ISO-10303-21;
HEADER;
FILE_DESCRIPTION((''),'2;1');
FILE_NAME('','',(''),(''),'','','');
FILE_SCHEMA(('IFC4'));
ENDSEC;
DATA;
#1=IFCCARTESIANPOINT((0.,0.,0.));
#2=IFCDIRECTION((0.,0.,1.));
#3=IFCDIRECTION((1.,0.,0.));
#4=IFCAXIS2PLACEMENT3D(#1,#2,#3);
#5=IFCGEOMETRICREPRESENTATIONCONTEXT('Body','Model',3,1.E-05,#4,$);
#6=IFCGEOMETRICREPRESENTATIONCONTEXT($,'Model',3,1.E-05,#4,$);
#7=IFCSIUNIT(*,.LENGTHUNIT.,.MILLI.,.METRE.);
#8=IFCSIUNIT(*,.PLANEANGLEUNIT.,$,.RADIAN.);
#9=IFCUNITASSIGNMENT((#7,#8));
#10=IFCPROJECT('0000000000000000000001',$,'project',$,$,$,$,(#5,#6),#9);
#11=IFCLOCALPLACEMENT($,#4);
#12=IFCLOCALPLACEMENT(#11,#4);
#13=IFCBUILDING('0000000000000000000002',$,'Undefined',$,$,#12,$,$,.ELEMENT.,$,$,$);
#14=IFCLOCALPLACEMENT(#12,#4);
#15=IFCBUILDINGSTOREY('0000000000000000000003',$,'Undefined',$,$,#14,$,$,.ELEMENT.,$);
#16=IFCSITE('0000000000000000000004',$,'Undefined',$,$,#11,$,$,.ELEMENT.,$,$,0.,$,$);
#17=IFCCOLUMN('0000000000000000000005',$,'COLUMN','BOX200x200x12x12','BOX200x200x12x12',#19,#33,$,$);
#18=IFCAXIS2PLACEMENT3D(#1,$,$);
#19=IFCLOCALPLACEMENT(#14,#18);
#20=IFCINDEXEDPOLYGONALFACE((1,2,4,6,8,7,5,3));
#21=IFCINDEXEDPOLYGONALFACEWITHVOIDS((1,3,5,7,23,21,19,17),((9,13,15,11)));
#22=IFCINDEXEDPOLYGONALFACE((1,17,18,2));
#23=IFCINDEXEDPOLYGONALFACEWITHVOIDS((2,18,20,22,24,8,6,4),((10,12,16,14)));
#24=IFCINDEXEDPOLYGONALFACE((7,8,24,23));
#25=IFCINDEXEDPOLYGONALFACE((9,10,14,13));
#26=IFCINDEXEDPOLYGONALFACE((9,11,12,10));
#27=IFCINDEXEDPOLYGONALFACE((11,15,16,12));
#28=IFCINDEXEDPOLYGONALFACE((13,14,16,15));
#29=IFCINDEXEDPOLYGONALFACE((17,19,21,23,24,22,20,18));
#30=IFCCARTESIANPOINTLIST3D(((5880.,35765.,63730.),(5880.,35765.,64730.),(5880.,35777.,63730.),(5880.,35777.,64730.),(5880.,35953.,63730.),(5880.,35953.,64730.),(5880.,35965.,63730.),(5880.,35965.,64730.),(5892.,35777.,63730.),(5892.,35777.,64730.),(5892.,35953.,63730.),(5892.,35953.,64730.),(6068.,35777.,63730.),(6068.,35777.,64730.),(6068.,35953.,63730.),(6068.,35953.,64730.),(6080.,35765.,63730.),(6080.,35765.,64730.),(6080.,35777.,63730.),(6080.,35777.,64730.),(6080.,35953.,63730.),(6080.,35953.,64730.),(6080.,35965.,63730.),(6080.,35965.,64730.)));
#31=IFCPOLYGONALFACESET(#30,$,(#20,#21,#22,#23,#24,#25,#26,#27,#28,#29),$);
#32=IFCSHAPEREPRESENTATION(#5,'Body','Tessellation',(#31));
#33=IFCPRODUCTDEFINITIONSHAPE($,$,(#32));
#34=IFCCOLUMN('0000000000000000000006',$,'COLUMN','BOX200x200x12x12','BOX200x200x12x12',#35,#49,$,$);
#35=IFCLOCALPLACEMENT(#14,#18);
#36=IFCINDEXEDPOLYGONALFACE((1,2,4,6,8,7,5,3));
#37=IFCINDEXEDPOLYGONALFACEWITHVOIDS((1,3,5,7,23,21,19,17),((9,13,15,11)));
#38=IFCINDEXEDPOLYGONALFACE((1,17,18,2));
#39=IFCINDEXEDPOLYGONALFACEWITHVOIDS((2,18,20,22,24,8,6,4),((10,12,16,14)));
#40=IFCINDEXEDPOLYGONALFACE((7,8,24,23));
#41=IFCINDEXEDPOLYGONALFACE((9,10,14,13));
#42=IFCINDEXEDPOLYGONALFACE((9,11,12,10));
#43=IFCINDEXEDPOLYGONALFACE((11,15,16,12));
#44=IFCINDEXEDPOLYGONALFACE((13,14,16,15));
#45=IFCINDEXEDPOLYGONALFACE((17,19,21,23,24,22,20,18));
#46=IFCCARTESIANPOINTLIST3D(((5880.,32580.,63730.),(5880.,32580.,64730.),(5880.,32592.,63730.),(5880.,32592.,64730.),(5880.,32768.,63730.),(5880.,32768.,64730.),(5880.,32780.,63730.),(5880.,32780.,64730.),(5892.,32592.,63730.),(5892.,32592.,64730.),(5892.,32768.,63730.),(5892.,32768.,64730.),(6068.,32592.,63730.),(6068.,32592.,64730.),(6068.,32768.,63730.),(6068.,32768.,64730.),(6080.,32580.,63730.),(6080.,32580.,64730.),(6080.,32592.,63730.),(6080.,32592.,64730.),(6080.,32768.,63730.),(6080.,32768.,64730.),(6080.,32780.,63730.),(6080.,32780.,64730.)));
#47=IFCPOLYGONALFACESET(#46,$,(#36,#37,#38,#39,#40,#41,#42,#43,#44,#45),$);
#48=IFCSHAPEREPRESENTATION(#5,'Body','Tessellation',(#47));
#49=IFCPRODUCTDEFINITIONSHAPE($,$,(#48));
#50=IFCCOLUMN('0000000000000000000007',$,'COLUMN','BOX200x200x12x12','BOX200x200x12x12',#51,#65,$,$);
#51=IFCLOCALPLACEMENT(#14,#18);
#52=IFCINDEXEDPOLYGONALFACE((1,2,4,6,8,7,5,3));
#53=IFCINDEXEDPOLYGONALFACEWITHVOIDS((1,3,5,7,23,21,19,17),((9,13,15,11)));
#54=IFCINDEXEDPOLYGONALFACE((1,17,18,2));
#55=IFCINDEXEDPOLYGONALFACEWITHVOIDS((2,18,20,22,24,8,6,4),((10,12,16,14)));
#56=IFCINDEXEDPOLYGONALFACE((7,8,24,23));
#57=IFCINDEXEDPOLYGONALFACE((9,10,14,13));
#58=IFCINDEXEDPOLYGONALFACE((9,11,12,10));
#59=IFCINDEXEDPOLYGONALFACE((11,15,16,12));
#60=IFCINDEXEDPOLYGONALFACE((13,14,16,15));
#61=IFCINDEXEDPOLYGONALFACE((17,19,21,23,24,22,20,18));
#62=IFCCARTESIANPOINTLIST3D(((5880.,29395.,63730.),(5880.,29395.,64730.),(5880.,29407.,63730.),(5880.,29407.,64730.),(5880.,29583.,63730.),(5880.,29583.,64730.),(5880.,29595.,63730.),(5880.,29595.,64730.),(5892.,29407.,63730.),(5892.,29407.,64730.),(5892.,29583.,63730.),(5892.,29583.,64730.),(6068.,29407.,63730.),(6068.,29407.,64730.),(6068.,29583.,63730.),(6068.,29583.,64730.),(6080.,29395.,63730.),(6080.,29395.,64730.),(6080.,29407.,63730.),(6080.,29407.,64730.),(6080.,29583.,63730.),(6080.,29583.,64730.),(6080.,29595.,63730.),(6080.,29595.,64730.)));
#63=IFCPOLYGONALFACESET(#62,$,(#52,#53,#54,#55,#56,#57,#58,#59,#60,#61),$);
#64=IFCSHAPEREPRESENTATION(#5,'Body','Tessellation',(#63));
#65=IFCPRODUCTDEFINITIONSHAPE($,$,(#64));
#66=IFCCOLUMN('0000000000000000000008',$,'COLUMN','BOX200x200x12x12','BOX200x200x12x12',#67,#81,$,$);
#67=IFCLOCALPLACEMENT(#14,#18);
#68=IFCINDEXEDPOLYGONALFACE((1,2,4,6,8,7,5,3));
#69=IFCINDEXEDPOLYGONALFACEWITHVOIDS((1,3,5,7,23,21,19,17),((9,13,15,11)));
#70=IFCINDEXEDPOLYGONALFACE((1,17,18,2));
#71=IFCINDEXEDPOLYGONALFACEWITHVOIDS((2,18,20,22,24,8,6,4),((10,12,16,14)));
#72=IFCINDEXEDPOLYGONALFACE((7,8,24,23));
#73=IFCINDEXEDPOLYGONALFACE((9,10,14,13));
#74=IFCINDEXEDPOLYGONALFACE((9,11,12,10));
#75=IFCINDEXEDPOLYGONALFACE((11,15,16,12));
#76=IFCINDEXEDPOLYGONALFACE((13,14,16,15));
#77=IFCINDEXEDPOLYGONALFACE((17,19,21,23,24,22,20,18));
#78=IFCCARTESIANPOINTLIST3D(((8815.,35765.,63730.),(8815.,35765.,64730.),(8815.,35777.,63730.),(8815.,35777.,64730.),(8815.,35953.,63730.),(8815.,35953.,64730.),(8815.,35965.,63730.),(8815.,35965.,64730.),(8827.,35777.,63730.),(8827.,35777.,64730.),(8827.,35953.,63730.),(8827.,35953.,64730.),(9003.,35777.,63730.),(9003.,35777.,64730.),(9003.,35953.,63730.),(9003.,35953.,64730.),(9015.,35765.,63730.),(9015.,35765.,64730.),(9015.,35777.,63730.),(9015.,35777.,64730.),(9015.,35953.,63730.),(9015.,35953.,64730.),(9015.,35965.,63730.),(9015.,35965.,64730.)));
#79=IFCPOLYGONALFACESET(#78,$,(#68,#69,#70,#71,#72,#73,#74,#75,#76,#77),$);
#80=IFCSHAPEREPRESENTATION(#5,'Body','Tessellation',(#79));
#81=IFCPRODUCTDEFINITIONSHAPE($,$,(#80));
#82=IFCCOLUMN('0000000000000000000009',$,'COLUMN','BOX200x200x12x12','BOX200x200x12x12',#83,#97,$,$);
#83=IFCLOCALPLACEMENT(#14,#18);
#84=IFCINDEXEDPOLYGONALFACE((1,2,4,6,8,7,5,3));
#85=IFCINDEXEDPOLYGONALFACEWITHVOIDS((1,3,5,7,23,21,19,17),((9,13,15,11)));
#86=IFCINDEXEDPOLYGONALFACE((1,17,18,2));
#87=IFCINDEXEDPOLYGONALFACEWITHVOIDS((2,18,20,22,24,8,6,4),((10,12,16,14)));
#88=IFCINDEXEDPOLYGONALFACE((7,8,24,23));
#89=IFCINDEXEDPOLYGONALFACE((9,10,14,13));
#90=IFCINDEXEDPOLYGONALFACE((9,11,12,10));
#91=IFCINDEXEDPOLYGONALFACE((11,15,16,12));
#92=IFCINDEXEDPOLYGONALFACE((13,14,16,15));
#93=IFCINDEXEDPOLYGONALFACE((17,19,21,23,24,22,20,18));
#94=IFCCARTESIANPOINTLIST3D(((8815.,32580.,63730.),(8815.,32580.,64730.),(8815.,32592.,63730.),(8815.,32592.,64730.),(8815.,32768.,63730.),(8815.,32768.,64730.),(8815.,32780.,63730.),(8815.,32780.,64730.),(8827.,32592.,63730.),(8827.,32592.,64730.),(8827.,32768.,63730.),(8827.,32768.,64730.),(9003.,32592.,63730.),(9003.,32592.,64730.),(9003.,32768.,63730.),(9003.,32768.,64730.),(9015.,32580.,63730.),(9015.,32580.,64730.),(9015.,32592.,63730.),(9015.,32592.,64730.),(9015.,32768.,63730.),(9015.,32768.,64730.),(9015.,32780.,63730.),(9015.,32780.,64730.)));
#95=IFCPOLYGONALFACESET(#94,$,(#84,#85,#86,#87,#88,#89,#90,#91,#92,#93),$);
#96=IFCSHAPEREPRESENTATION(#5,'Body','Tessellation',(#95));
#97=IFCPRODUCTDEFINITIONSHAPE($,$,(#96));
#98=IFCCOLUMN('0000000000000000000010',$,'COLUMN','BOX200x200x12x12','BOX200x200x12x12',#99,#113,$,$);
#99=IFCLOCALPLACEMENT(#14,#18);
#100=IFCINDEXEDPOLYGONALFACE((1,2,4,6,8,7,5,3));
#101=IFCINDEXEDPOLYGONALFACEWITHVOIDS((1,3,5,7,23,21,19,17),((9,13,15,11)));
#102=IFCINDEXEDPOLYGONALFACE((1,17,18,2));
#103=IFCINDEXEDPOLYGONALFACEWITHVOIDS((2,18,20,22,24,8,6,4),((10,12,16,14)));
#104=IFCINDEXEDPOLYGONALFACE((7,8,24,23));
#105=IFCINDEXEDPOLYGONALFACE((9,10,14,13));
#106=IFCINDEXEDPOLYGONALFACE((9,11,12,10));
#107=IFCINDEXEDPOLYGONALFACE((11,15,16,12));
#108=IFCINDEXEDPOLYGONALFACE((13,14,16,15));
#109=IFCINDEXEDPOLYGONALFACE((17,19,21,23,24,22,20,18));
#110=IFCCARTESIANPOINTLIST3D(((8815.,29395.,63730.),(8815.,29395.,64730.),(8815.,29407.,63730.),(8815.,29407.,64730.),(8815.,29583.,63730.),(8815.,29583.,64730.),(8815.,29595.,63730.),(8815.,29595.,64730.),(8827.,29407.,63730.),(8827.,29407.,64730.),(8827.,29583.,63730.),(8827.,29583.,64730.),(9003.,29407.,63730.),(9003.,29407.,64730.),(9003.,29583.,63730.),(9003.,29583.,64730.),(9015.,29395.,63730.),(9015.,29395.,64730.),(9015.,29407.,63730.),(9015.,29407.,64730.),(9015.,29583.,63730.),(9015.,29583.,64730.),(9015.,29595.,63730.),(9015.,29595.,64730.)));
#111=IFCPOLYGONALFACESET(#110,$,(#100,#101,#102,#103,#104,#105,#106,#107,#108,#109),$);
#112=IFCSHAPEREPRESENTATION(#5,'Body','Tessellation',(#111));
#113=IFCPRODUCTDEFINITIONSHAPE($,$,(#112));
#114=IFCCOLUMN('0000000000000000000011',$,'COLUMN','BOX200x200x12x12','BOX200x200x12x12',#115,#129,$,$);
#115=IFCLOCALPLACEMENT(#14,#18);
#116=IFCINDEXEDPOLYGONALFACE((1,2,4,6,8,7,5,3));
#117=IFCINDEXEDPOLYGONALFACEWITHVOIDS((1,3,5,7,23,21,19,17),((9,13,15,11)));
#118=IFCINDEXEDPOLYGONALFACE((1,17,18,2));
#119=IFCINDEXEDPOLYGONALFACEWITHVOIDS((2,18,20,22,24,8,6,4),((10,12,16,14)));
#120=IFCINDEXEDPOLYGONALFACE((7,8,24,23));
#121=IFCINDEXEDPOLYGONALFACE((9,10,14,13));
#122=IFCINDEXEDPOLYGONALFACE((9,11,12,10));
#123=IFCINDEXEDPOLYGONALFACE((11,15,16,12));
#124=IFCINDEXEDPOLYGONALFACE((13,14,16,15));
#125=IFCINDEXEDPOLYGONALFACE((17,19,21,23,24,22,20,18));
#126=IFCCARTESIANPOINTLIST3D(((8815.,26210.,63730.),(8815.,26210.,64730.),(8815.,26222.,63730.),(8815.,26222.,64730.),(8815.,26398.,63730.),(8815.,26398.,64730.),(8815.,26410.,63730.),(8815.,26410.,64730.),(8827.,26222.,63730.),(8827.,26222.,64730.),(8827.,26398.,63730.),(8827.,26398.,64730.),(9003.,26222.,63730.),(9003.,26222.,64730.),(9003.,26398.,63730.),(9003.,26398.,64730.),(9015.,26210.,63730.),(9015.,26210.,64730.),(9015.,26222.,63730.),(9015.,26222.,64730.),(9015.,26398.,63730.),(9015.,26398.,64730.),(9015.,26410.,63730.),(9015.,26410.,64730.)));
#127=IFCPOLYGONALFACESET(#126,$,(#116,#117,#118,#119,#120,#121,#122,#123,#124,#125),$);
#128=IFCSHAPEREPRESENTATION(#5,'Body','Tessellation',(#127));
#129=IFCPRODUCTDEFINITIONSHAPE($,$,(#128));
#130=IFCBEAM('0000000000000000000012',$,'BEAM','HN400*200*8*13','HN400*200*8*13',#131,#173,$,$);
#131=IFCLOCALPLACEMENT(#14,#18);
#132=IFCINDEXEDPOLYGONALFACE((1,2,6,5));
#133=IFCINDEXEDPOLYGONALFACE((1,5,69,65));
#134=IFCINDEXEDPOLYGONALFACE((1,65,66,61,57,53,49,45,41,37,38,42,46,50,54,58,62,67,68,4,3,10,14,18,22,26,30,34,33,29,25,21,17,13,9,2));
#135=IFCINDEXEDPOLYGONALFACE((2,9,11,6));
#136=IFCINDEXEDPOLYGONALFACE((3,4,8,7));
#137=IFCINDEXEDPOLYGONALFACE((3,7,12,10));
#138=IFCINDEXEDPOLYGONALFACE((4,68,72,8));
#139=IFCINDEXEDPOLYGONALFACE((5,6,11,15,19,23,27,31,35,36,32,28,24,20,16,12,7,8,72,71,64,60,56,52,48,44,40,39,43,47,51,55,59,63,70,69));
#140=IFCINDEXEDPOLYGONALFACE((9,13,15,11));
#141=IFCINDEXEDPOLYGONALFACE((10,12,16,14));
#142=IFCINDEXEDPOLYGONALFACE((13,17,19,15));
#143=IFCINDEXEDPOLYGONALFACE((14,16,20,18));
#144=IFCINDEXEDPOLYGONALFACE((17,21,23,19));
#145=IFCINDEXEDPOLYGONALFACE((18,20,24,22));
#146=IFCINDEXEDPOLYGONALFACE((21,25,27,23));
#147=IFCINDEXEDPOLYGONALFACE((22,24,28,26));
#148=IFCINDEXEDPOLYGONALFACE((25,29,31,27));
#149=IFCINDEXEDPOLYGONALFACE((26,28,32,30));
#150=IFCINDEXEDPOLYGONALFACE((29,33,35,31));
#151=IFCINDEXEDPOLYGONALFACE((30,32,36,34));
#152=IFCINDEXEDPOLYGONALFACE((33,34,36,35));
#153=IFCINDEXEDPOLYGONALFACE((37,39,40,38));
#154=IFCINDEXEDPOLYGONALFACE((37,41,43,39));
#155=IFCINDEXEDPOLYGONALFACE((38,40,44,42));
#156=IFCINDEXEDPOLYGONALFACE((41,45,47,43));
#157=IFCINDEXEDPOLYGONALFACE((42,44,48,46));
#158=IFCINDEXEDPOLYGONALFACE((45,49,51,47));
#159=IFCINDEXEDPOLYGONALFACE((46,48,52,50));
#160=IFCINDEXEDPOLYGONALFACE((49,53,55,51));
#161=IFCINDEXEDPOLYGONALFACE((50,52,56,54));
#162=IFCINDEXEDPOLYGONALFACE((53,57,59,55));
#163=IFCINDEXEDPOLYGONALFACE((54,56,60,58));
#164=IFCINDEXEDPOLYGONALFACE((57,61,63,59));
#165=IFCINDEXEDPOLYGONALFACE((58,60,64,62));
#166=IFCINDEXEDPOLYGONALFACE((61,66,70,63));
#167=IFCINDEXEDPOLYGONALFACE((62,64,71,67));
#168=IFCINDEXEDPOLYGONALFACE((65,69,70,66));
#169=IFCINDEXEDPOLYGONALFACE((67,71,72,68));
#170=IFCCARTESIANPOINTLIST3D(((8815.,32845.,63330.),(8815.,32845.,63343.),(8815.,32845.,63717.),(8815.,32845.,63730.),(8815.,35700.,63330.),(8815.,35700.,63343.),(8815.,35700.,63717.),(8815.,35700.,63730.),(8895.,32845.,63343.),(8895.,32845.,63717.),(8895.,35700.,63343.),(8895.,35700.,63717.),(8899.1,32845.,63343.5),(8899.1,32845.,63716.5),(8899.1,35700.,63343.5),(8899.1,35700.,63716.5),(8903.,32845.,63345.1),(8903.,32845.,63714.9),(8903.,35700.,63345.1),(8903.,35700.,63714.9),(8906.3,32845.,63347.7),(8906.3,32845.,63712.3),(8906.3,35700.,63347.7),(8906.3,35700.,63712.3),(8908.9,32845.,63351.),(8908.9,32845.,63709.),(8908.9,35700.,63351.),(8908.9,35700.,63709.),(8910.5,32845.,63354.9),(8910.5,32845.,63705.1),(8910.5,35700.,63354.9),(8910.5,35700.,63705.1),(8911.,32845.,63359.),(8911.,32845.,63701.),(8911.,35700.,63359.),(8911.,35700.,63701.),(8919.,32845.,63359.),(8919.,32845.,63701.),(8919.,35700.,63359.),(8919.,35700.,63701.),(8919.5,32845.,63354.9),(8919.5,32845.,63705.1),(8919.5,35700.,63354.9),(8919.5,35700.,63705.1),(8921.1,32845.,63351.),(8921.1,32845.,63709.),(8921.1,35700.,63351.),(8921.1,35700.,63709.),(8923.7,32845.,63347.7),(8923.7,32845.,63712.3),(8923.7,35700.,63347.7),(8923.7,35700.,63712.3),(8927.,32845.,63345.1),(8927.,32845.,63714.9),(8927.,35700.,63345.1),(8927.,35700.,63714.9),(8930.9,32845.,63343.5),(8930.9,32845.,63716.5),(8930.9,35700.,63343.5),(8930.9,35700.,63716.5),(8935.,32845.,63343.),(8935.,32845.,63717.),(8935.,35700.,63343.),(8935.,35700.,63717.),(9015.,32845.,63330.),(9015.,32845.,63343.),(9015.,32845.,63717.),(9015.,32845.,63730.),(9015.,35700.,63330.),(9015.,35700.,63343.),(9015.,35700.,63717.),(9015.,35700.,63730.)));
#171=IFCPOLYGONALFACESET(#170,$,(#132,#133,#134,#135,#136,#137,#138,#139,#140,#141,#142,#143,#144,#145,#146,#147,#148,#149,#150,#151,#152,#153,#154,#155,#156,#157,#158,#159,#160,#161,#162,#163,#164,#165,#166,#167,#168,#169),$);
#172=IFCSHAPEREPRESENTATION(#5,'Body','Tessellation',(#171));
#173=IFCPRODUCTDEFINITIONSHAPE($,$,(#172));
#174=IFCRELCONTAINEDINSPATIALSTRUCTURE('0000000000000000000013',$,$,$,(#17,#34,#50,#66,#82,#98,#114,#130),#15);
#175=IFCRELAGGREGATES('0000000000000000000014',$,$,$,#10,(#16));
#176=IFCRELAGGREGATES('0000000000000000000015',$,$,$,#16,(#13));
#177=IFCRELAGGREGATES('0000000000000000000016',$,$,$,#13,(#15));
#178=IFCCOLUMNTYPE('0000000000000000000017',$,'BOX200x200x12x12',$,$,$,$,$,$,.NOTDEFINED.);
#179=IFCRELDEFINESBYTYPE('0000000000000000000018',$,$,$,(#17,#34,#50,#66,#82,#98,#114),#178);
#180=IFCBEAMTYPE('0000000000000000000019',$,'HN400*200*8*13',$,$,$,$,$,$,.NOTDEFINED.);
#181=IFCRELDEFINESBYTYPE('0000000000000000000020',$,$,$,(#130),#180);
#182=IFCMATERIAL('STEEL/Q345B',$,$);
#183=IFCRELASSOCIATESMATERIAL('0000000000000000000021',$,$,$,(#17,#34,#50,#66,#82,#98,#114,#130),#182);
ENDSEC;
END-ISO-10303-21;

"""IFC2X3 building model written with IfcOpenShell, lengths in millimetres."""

from ifc_helpers import new_model, si_unit, frame, origin_with_axes, origin_2d_with_axis, place, context, project, spatial, polyline, i_section, outline, extrude, material, type_object, element, save


model = new_model("IFC2X3")

# Units and contexts
model_context_1 = context("Model", 3, precision=1e-05, world=origin_with_axes(), identifier="Body")
model_context_2 = context("Model", 3, precision=1e-05, world=origin_with_axes())
ifc_project = project(units=[si_unit("LENGTHUNIT", "METRE", prefix="MILLI"), si_unit("PLANEANGLEUNIT", "RADIAN")], contexts=[model_context_1, model_context_2])

# Site, building, storey
site_placement = place(None, origin_with_axes())
site = spatial("IfcSite", under=ifc_project, at=site_placement, Name="Undefined", CompositionType="ELEMENT", RefElevation=0.0)
building_placement = place(site_placement, origin_with_axes())
building = spatial("IfcBuilding", under=site, at=building_placement, Name="Undefined", CompositionType="ELEMENT")
storey_placement = place(building_placement, origin_with_axes())
storey = spatial("IfcBuildingStorey", under=building, at=storey_placement, Name="Undefined", CompositionType="ELEMENT")

# Columns
ifc_material_1 = material(Name="STEEL/Q345B")
column_type = type_object("IfcColumnType", Name="BOX200x200x12x12", PredefinedType="NOTDEFINED")
for number, where, z_axis, x_axis, name in (
    (1, (5980.0, 35865.0, 63730.0), (0.0, 0.0, 1.0), (1.0, 0.0, 0.0), "COLUMN"),
    (2, (5980.0, 32680.0, 63730.0), (0.0, 0.0, 1.0), (1.0, 0.0, 0.0), "COLUMN"),
):
    element("IfcColumn", number, at=place(storey_placement, frame(where, z_axis=z_axis, x_axis=x_axis)), inside=storey, type_object=column_type, material=ifc_material_1, Name=name, Description="BOX200x200x12x12", ObjectType="BOX200x200x12x12", context=model_context_1, shape_type="SweptSolid", body=[
        extrude(outline(polyline([(-100.0, -100.0), (100.0, -100.0), (100.0, -88.0), (100.0, 88.0), (100.0, 100.0), (-100.0, 100.0), (-100.0, 88.0), (-100.0, -88.0), (-100.0, -100.0)]), holes=[polyline([(-88.0, -88.0), (-88.0, 88.0), (88.0, 88.0), (88.0, -88.0), (-88.0, -88.0)])]), frame((0.0, 0.0, 1000.0), z_axis=(0.0, 0.0, -1.0), x_axis=(-1.0, 0.0, 0.0)), (0.0, 0.0, 1.0), 1000.0),
    ])
column_placement = place(storey_placement, frame((5980.0, 29495.0, 63730.0), z_axis=(0.0, 0.0, 1.0), x_axis=(1.0, 0.0, 0.0)))
element("IfcColumn", 3, at=column_placement, inside=storey, type_object=column_type, material=ifc_material_1, Name="COLUMN", Description="BOX200x200x12x12", ObjectType="BOX200x200x12x12", context=model_context_1, shape_type="SweptSolid", body=[
    extrude(outline(polyline([(-100.0, -100.0), (100.0, -100.0), (100.0, -88.0), (100.0, 88.0), (100.0, 100.0), (-100.0, 100.0), (-100.0, 88.0), (-100.0, -88.0), (-100.0, -100.0)]), holes=[polyline([(-88.0, -88.0), (-88.0, 88.0), (88.0, 88.0), (88.0, -88.0), (-88.0, -88.0)])]), frame((0.0, 0.0, 1000.0), z_axis=(0.0, 0.0, -1.0), x_axis=(-1.0, 0.0, 0.0)), (0.0, 0.0, 1.0), 1000.0),
])
for number, where, z_axis, x_axis, name in (
    (4, (8915.0, 35865.0, 63730.0), (0.0, 0.0, 1.0), (1.0, 0.0, 0.0), "COLUMN"),
    (5, (8915.0, 32680.0, 63730.0), (0.0, 0.0, 1.0), (1.0, 0.0, 0.0), "COLUMN"),
    (6, (8915.0, 29495.0, 63730.0), (0.0, 0.0, 1.0), (1.0, 0.0, 0.0), "COLUMN"),
    (7, (8915.0, 26310.0, 63730.0), (0.0, 0.0, 1.0), (1.0, 0.0, 0.0), "COLUMN"),
):
    element("IfcColumn", number, at=place(storey_placement, frame(where, z_axis=z_axis, x_axis=x_axis)), inside=storey, type_object=column_type, material=ifc_material_1, Name=name, Description="BOX200x200x12x12", ObjectType="BOX200x200x12x12", context=model_context_1, shape_type="SweptSolid", body=[
        extrude(outline(polyline([(-100.0, -100.0), (100.0, -100.0), (100.0, -88.0), (100.0, 88.0), (100.0, 100.0), (-100.0, 100.0), (-100.0, 88.0), (-100.0, -88.0), (-100.0, -100.0)]), holes=[polyline([(-88.0, -88.0), (-88.0, 88.0), (88.0, 88.0), (88.0, -88.0), (-88.0, -88.0)])]), frame((0.0, 0.0, 1000.0), z_axis=(0.0, 0.0, -1.0), x_axis=(-1.0, 0.0, 0.0)), (0.0, 0.0, 1.0), 1000.0),
    ])

# Beam
beam_type_1 = type_object("IfcBeamType", Name="HN400*200*8*13", PredefinedType="NOTDEFINED")
for number, where, z_axis, x_axis, name in (
    (8, (8915.0, 32680.0, 63530.0), (0.0, 0.0, 1.0), (0.0, 1.0, 0.0), "BEAM"),
):
    element("IfcBeam", number, at=place(storey_placement, frame(where, z_axis=z_axis, x_axis=x_axis)), inside=storey, type_object=beam_type_1, material=ifc_material_1, Name=name, Description="HN400*200*8*13", ObjectType="HN400*200*8*13", context=model_context_1, shape_type="SweptSolid", body=[
        extrude(i_section(OverallWidth=200.0, OverallDepth=400.0, WebThickness=8.0, FlangeThickness=13.0, FilletRadius=16.0, at=origin_2d_with_axis()), frame((3020.0, 0.0, 0.0), z_axis=(-1.0, 0.0, 0.0), x_axis=(0.0, -1.0, 0.0)), (0.0, 0.0, 1.0), 2855.0),
    ])

save(model, "model.ifc")
